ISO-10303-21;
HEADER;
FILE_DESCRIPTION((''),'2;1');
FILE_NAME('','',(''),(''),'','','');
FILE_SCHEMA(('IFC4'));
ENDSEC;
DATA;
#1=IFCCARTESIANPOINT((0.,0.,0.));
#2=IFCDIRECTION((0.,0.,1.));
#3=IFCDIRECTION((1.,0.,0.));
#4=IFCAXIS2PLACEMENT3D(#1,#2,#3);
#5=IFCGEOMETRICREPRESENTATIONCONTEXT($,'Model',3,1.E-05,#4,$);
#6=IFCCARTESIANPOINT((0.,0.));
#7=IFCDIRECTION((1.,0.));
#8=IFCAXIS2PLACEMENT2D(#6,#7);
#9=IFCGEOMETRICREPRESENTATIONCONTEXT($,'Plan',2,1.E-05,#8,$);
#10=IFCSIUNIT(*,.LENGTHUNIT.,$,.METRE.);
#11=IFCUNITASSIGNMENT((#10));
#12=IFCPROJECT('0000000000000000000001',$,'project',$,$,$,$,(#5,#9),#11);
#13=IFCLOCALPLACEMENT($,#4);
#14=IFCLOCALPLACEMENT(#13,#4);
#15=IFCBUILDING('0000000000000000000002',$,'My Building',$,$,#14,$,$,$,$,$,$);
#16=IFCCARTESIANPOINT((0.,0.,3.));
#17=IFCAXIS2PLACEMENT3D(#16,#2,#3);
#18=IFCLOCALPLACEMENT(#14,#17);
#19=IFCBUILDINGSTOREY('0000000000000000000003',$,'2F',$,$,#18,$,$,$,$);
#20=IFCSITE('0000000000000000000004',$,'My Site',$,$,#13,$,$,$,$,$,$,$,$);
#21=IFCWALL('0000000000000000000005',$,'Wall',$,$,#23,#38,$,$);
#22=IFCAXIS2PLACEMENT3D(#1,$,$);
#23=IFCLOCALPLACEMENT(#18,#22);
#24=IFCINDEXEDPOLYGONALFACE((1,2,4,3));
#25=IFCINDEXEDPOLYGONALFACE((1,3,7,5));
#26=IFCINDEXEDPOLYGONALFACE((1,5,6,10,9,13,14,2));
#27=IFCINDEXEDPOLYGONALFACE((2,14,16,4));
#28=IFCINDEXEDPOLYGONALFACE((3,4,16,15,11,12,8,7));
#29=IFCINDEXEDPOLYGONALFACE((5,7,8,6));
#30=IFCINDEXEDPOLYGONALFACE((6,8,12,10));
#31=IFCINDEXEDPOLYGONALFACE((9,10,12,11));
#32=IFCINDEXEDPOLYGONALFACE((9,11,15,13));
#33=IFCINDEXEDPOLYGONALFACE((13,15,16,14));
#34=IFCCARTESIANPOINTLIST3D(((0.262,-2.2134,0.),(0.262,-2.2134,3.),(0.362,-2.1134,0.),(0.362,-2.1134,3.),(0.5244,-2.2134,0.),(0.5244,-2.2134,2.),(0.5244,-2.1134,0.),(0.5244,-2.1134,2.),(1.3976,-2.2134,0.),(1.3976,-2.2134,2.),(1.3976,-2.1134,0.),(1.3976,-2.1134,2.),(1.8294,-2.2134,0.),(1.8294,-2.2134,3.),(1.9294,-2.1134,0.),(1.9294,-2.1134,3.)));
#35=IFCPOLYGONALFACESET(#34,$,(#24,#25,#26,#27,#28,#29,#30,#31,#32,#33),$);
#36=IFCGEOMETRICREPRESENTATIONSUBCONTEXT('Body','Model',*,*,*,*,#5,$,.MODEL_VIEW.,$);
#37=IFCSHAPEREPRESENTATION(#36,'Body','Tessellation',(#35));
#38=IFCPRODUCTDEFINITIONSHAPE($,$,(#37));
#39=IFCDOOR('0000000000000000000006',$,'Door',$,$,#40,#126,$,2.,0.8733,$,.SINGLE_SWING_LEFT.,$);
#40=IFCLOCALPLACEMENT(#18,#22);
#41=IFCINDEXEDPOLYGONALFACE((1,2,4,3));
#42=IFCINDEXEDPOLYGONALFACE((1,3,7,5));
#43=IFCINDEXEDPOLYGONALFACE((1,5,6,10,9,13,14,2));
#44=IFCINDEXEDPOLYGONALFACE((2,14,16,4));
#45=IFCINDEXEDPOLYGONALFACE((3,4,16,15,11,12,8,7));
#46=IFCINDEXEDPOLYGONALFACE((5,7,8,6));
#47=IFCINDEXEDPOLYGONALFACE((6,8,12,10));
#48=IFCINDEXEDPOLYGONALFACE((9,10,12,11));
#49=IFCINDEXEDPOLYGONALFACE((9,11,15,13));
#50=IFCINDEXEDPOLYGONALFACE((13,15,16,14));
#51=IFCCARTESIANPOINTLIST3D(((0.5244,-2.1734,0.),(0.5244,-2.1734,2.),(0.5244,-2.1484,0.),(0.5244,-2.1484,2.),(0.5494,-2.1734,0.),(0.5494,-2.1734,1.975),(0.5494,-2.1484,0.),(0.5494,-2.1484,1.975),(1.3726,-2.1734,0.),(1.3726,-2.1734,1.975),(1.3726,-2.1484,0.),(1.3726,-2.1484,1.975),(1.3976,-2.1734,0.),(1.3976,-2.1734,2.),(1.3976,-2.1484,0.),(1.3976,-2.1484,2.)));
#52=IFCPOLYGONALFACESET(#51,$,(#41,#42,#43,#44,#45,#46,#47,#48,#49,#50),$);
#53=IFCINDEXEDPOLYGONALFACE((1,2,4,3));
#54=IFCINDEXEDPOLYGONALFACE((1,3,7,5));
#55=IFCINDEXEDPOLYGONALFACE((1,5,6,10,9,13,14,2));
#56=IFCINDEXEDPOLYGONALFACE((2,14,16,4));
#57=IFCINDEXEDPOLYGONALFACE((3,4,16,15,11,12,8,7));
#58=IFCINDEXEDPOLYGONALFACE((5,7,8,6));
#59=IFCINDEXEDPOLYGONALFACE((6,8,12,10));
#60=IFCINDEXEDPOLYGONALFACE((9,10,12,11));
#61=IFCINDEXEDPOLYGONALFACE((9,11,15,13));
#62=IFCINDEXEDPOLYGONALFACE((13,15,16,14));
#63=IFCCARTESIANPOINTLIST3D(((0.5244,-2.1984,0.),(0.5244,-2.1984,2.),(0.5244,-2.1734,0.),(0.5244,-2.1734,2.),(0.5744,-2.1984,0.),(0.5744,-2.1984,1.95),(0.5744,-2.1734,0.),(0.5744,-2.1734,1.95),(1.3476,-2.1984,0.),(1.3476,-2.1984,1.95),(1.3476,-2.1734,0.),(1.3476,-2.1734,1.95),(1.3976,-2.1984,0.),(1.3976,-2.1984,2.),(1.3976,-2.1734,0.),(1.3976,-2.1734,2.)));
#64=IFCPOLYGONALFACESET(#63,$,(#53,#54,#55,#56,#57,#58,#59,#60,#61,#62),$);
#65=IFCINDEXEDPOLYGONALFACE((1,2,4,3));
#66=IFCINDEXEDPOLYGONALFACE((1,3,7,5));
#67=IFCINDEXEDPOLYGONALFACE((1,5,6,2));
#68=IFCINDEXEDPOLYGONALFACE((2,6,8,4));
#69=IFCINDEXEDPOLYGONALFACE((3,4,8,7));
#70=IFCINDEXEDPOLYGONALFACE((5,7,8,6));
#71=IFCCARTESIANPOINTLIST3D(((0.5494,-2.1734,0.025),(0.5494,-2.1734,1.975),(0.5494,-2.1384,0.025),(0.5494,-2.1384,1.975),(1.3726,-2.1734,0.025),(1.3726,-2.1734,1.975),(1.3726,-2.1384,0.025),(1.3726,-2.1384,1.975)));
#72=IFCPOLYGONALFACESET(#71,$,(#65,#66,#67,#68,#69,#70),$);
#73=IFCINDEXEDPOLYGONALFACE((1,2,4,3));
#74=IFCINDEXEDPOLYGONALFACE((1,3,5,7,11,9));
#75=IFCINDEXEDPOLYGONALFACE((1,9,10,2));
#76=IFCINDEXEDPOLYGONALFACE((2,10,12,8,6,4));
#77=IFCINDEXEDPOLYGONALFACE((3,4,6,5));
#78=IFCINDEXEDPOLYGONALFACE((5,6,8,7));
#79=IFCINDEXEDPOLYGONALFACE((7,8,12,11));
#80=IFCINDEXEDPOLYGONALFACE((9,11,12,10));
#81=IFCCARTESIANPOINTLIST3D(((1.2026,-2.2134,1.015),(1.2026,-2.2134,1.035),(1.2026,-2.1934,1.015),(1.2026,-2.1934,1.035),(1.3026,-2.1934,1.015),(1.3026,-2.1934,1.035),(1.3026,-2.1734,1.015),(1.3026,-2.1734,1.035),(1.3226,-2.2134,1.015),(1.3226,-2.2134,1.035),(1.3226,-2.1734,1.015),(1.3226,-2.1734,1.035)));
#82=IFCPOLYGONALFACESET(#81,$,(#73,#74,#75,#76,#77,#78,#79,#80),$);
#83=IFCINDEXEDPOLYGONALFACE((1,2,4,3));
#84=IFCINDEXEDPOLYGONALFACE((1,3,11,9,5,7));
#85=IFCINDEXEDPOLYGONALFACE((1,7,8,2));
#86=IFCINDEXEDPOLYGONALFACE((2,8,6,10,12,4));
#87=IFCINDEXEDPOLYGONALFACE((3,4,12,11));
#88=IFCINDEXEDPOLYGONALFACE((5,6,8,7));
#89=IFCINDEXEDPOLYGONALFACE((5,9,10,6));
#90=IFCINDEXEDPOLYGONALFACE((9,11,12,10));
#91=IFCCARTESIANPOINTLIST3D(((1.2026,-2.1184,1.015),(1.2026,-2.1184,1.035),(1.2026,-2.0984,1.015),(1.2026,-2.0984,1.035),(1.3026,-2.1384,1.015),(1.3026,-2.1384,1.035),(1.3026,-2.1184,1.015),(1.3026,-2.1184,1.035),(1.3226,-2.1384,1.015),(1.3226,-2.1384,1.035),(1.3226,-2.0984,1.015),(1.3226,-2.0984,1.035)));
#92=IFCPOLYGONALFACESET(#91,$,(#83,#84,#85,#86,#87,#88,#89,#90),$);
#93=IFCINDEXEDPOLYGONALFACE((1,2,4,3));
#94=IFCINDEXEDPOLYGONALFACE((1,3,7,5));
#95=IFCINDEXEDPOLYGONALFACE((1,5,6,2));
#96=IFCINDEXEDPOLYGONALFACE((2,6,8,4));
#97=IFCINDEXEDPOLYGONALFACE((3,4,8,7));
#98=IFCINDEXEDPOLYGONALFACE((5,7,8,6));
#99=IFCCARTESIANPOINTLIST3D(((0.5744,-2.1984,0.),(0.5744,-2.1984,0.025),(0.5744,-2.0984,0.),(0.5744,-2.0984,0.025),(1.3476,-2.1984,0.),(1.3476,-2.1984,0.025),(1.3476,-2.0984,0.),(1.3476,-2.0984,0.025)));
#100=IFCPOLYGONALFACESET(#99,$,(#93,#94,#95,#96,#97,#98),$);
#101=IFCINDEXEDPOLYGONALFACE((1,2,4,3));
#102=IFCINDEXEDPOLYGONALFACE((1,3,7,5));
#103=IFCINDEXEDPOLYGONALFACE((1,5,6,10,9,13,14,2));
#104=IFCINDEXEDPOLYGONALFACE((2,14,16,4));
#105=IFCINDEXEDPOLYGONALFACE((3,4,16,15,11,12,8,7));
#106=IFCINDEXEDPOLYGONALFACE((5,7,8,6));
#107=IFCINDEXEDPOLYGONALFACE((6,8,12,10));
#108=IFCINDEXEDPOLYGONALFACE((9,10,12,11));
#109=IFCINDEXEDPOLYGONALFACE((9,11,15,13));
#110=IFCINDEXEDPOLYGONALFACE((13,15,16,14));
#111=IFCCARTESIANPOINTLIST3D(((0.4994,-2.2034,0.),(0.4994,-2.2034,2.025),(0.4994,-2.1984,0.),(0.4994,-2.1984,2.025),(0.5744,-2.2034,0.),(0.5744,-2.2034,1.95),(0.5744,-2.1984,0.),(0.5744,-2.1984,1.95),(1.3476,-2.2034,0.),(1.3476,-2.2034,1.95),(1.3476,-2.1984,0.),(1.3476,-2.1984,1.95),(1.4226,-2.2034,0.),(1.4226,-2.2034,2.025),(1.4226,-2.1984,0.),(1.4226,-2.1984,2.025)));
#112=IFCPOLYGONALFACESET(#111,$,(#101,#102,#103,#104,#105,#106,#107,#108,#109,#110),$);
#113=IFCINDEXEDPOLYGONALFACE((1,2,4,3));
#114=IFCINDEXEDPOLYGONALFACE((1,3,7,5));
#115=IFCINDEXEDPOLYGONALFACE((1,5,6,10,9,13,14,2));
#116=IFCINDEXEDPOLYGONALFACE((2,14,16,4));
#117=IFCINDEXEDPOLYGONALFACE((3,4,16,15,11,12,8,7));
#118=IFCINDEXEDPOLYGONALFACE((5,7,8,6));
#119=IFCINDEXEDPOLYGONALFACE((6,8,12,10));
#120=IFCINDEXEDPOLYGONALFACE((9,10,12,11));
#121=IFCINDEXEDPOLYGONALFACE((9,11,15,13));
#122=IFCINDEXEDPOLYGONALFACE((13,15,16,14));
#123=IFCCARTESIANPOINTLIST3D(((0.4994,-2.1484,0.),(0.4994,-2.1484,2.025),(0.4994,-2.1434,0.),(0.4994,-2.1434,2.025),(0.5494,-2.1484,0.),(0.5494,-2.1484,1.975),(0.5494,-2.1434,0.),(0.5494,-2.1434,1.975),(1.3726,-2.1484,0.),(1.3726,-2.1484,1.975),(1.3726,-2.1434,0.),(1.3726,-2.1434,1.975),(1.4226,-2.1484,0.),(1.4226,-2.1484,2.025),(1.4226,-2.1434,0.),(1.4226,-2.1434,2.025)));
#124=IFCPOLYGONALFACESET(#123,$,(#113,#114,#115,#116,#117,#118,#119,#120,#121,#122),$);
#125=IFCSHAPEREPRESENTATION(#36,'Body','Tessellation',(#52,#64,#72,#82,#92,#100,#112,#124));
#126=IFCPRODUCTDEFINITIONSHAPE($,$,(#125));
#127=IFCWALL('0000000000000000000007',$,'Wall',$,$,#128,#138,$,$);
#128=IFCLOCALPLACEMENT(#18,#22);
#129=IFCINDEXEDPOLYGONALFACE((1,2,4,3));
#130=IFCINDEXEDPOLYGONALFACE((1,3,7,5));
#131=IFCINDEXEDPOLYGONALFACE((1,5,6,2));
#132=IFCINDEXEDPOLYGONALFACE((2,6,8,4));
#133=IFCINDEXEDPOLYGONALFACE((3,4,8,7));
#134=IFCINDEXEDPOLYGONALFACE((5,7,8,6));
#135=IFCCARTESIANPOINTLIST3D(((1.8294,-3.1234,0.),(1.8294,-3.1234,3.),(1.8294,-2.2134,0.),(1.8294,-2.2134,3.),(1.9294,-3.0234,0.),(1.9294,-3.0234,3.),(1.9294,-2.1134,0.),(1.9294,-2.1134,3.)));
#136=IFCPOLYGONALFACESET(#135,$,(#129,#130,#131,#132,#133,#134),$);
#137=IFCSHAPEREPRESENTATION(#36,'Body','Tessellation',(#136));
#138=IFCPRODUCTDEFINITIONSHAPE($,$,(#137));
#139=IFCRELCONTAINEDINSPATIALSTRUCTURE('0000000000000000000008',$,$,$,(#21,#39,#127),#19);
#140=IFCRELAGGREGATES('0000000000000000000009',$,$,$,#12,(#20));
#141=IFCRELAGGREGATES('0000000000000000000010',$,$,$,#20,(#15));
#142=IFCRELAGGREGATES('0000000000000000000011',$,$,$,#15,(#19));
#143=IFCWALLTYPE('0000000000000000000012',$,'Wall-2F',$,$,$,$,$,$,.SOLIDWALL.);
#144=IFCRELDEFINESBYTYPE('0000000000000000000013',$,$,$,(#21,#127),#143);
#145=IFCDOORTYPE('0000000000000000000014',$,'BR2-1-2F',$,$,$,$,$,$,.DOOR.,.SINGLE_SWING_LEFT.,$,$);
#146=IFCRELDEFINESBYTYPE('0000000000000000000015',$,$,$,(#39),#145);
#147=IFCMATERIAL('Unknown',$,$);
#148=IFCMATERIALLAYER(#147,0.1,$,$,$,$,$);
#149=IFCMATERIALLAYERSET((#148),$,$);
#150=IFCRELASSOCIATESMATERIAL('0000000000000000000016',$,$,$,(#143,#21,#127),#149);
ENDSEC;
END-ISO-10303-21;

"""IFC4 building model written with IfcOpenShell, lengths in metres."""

from ifc_helpers import new_model, entity, si_unit, frame, origin_with_axes, origin_2d_with_axis, place, context, subcontext, project, spatial, line, indexed_curve, outline, extrude, shape, source, transform, mapped, material, layer, layer_set, layer_usage, type_object, type_shapes, element, fill, save


model = new_model("IFC4")

# Units and contexts
model_context = context("Model", 3, precision=1e-05, world=origin_with_axes())
plan_context = context("Plan", 2, precision=1e-05, world=origin_2d_with_axis())
body_context_1 = subcontext(model_context, "Body", "Model", "MODEL_VIEW")
body_context_2 = subcontext(plan_context, "Body", "Plan", "PLAN_VIEW")
ifc_project = project(units=[si_unit("LENGTHUNIT", "METRE")], contexts=[model_context, plan_context])

# Site, building, storey
site_placement = place(None, origin_with_axes())
site = spatial("IfcSite", under=ifc_project, at=site_placement, Name="My Site")
building_placement = place(site_placement, origin_with_axes())
building = spatial("IfcBuilding", under=site, at=building_placement, Name="My Building")
storey_placement = place(building_placement, frame((0.0, 0.0, 3.0), z_axis=(0.0, 0.0, 1.0), x_axis=(1.0, 0.0, 0.0)))
storey = spatial("IfcBuildingStorey", under=building, at=storey_placement, Name="2F")

# Shared definitions
ifc_material = material(Name="Unknown")
ifc_layer_1 = layer(ifc_material, 0.1)
ifc_layer_set_1 = layer_set([ifc_layer_1])
wall_type_1 = type_object("IfcWallType", Name="Wall-2F", PredefinedType="SOLIDWALL", material=ifc_layer_set_1)

# Wall, opening, door
ifc_layer_usage_1 = layer_usage(ifc_layer_set_1, "AXIS2", "POSITIVE", 0.0)
wall_1_placement = place(storey_placement, frame((0.262, -2.2134, 0.0), z_axis=(0.0, 0.0, 1.0), x_axis=(1.0, 0.0, 0.0)))
wall_1 = element("IfcWall", 1, at=wall_1_placement, inside=storey, type_object=wall_type_1, material=ifc_layer_usage_1, Name="Wall", context=body_context_1, shape_type="SweptSolid", body=[
    extrude(outline(indexed_curve([(0.0, 0.0), (0.1, 0.1), (1.6674, 0.1), (1.5674, 0.0)], segments=[line(1, 2, 3, 4, 1)])), origin_with_axes(), (0.0, 0.0, 1.0), 3.0),
])
shared_shape_1 = source(origin_with_axes(), body_context_1, "Body", "SweptSolid", [
    extrude(outline(indexed_curve([(0.0, 0.0), (0.8733, 0.0), (0.8733, 2.0), (0.0, 2.0)], segments=[line(1, 2, 3, 4, 1)])), frame((0.0, -0.6, 0.0), z_axis=(0.0, -1.0, 0.0), x_axis=(1.0, 0.0, 0.0)), (0.0, 0.0, -1.0), 1.2),
])
opening_1_placement = place(wall_1_placement, frame((0.2623, 0.015, 0.0), z_axis=(0.0, 0.0, 1.0), x_axis=(1.0, 0.0, 0.0)))
opening_1 = element("IfcOpeningElement", 2, at=opening_1_placement, cuts=wall_1, PredefinedType="OPENING", context=body_context_1, shape_type="MappedRepresentation", body=[
    mapped(shared_shape_1, transform((0.0, 0.0, 0.0), x_axis=(1.0, 0.0, 0.0), y_axis=(0.0, 1.0, 0.0), z_axis=(0.0, 0.0, 1.0), scale=1.0)),
])
door_type_1 = type_object("IfcDoorType", Name="BR2-1-2F", OperationType="SINGLE_SWING_LEFT", PredefinedType="DOOR")
shared_shape_2 = source(origin_with_axes(), body_context_1, "Body", "SweptSolid", [
    extrude(outline(indexed_curve([(0.0, 0.0), (0.0, 2.0), (0.8733, 2.0), (0.8733, 0.0), (0.8483, 0.0), (0.8483, 1.975), (0.025, 1.975), (0.025, 0.0)], segments=[line(1, 2, 3, 4, 5, 6, 7, 8, 1)])), frame((0.0, 0.025, 0.0), z_axis=(0.0, -1.0, 0.0), x_axis=(1.0, 0.0, 0.0)), (0.0, 0.0, -1.0), 0.025),
    extrude(outline(indexed_curve([(0.0, 0.0), (0.0, 2.0), (0.8733, 2.0), (0.8733, 0.0), (0.8233, 0.0), (0.8233, 1.95), (0.05, 1.95), (0.05, 0.0)], segments=[line(1, 2, 3, 4, 5, 6, 7, 8, 1)])), frame((0.0, 0.0, 0.0), z_axis=(0.0, -1.0, 0.0), x_axis=(1.0, 0.0, 0.0)), (0.0, 0.0, -1.0), 0.025),
    extrude(outline(indexed_curve([(0.0, 0.0), (0.8233, 0.0), (0.8233, 0.035), (0.0, 0.035)], segments=[line(1, 2, 3, 4, 1)])), frame((0.025, 0.025, 0.025), z_axis=(0.0, 0.0, 1.0), x_axis=(1.0, 0.0, 0.0)), (0.0, 0.0, 1.0), 1.95),
    extrude(outline(indexed_curve([(0.0, 0.0), (0.0, -0.04), (-0.12, -0.04), (-0.12, -0.02), (-0.02, -0.02), (-0.02, 0.0)], segments=[line(1, 2, 3, 4, 5, 6, 1)])), frame((0.7983, 0.025, 1.015), z_axis=(0.0, 0.0, 1.0), x_axis=(1.0, 0.0, 0.0)), (0.0, 0.0, 1.0), 0.02),
    extrude(outline(indexed_curve([(0.0, 0.0), (0.0, 0.04), (-0.12, 0.04), (-0.12, 0.02), (-0.02, 0.02), (-0.02, 0.0)], segments=[line(1, 2, 3, 4, 5, 6, 1)])), frame((0.7983, 0.06, 1.015), z_axis=(0.0, 0.0, 1.0), x_axis=(1.0, 0.0, 0.0)), (0.0, 0.0, 1.0), 0.02),
    extrude(outline(indexed_curve([(0.0, 0.0), (0.7733, 0.0), (0.7733, 0.1), (0.0, 0.1)], segments=[line(1, 2, 3, 4, 1)])), frame((0.05, 0.0, 0.0), z_axis=(0.0, 0.0, 1.0), x_axis=(1.0, 0.0, 0.0)), (0.0, 0.0, 1.0), 0.025),
    extrude(outline(indexed_curve([(0.0, 0.0), (0.0, 2.025), (0.9233, 2.025), (0.9233, 0.0), (0.8483, 0.0), (0.8483, 1.95), (0.075, 1.95), (0.075, 0.0)], segments=[line(1, 2, 3, 4, 5, 6, 7, 8, 1)])), frame((-0.025, -0.005, 0.0), z_axis=(0.0, -1.0, 0.0), x_axis=(1.0, 0.0, 0.0)), (0.0, 0.0, -1.0), 0.005),
    extrude(outline(indexed_curve([(0.0, 0.0), (0.0, 2.025), (0.9233, 2.025), (0.9233, 0.0), (0.8733, 0.0), (0.8733, 1.975), (0.05, 1.975), (0.05, 0.0)], segments=[line(1, 2, 3, 4, 5, 6, 7, 8, 1)])), frame((-0.025, 0.05, 0.0), z_axis=(0.0, -1.0, 0.0), x_axis=(1.0, 0.0, 0.0)), (0.0, 0.0, -1.0), 0.005),
])
shared_shape_3 = source(origin_with_axes(), body_context_2, "Body", "Curve2D", [
    entity("IfcIndexedPolyCurve", entity("IfcCartesianPointList2D", [[0.0, 0.0], [0.0, 0.05], [0.025, 0.05], [0.025, 0.025], [0.05, 0.025], [0.05, 0.0]]), [entity("IfcLineIndex", [1, 2, 3, 4, 5, 6, 1])]),
    entity("IfcIndexedPolyCurve", entity("IfcCartesianPointList2D", [[0.8733, 0.0], [0.8733, 0.05], [0.8483, 0.05], [0.8483, 0.025], [0.8233, 0.025], [0.8233, 0.0]]), [entity("IfcLineIndex", [1, 2, 3, 4, 5, 6, 1])]),
    entity("IfcTrimmedCurve", entity("IfcEllipse", entity("IfcAxis2Placement2D", entity("IfcCartesianPoint", [0.06, 0.05]), entity("IfcDirection", [1.0, 0.0])), 0.7883, 0.8233), [entity("IfcCartesianPoint", [0.8483, 0.05])], [entity("IfcCartesianPoint", [0.06, 0.8733])], True, "CARTESIAN"),
    entity("IfcIndexedPolyCurve", entity("IfcCartesianPointList2D", [[0.025, 0.05], [0.06, 0.05], [0.06, 0.8733], [0.025, 0.8733]]), [entity("IfcLineIndex", [1, 2, 3, 4, 1])]),
])
type_shapes(door_type_1, [shared_shape_2, shared_shape_3])
door_1_placement = place(opening_1_placement, origin_with_axes())
door_1 = element("IfcDoor", 3, at=door_1_placement, inside=storey, type_object=door_type_1, Name="Door", OperationType="SINGLE_SWING_LEFT", OverallHeight=2.0, OverallWidth=0.8733, shapes=[
    shape(body_context_1, "Body", "MappedRepresentation", [mapped(shared_shape_2, transform((0.0, 0.0, 0.0), x_axis=(1.0, 0.0, 0.0), y_axis=(0.0, 1.0, 0.0), z_axis=(0.0, 0.0, 1.0), scale=1.0))]),
    shape(body_context_2, "Body", "MappedRepresentation", [mapped(shared_shape_3, transform((0.0, 0.0, 0.0), x_axis=(1.0, 0.0, 0.0), y_axis=(0.0, 1.0, 0.0), z_axis=(0.0, 0.0, 1.0), scale=1.0))]),
])
fill(opening_1, door_1)

# Wall
ifc_layer_usage_2 = layer_usage(ifc_layer_set_1, "AXIS2", "POSITIVE", 0.0)
wall_2_placement = place(storey_placement, frame((1.8294, -2.2134, 0.0), z_axis=(0.0, 0.0, 1.0), x_axis=(0.0, -1.0, 0.0)))
element("IfcWall", 4, at=wall_2_placement, inside=storey, type_object=wall_type_1, material=ifc_layer_usage_2, Name="Wall", context=body_context_1, shape_type="SweptSolid", body=[
    extrude(outline(indexed_curve([(0.0, 0.0), (-0.1, 0.1), (0.81, 0.1), (0.91, 0.0)], segments=[line(1, 2, 3, 4, 1)])), origin_with_axes(), (0.0, 0.0, 1.0), 3.0),
])

save(model, "model.ifc")
